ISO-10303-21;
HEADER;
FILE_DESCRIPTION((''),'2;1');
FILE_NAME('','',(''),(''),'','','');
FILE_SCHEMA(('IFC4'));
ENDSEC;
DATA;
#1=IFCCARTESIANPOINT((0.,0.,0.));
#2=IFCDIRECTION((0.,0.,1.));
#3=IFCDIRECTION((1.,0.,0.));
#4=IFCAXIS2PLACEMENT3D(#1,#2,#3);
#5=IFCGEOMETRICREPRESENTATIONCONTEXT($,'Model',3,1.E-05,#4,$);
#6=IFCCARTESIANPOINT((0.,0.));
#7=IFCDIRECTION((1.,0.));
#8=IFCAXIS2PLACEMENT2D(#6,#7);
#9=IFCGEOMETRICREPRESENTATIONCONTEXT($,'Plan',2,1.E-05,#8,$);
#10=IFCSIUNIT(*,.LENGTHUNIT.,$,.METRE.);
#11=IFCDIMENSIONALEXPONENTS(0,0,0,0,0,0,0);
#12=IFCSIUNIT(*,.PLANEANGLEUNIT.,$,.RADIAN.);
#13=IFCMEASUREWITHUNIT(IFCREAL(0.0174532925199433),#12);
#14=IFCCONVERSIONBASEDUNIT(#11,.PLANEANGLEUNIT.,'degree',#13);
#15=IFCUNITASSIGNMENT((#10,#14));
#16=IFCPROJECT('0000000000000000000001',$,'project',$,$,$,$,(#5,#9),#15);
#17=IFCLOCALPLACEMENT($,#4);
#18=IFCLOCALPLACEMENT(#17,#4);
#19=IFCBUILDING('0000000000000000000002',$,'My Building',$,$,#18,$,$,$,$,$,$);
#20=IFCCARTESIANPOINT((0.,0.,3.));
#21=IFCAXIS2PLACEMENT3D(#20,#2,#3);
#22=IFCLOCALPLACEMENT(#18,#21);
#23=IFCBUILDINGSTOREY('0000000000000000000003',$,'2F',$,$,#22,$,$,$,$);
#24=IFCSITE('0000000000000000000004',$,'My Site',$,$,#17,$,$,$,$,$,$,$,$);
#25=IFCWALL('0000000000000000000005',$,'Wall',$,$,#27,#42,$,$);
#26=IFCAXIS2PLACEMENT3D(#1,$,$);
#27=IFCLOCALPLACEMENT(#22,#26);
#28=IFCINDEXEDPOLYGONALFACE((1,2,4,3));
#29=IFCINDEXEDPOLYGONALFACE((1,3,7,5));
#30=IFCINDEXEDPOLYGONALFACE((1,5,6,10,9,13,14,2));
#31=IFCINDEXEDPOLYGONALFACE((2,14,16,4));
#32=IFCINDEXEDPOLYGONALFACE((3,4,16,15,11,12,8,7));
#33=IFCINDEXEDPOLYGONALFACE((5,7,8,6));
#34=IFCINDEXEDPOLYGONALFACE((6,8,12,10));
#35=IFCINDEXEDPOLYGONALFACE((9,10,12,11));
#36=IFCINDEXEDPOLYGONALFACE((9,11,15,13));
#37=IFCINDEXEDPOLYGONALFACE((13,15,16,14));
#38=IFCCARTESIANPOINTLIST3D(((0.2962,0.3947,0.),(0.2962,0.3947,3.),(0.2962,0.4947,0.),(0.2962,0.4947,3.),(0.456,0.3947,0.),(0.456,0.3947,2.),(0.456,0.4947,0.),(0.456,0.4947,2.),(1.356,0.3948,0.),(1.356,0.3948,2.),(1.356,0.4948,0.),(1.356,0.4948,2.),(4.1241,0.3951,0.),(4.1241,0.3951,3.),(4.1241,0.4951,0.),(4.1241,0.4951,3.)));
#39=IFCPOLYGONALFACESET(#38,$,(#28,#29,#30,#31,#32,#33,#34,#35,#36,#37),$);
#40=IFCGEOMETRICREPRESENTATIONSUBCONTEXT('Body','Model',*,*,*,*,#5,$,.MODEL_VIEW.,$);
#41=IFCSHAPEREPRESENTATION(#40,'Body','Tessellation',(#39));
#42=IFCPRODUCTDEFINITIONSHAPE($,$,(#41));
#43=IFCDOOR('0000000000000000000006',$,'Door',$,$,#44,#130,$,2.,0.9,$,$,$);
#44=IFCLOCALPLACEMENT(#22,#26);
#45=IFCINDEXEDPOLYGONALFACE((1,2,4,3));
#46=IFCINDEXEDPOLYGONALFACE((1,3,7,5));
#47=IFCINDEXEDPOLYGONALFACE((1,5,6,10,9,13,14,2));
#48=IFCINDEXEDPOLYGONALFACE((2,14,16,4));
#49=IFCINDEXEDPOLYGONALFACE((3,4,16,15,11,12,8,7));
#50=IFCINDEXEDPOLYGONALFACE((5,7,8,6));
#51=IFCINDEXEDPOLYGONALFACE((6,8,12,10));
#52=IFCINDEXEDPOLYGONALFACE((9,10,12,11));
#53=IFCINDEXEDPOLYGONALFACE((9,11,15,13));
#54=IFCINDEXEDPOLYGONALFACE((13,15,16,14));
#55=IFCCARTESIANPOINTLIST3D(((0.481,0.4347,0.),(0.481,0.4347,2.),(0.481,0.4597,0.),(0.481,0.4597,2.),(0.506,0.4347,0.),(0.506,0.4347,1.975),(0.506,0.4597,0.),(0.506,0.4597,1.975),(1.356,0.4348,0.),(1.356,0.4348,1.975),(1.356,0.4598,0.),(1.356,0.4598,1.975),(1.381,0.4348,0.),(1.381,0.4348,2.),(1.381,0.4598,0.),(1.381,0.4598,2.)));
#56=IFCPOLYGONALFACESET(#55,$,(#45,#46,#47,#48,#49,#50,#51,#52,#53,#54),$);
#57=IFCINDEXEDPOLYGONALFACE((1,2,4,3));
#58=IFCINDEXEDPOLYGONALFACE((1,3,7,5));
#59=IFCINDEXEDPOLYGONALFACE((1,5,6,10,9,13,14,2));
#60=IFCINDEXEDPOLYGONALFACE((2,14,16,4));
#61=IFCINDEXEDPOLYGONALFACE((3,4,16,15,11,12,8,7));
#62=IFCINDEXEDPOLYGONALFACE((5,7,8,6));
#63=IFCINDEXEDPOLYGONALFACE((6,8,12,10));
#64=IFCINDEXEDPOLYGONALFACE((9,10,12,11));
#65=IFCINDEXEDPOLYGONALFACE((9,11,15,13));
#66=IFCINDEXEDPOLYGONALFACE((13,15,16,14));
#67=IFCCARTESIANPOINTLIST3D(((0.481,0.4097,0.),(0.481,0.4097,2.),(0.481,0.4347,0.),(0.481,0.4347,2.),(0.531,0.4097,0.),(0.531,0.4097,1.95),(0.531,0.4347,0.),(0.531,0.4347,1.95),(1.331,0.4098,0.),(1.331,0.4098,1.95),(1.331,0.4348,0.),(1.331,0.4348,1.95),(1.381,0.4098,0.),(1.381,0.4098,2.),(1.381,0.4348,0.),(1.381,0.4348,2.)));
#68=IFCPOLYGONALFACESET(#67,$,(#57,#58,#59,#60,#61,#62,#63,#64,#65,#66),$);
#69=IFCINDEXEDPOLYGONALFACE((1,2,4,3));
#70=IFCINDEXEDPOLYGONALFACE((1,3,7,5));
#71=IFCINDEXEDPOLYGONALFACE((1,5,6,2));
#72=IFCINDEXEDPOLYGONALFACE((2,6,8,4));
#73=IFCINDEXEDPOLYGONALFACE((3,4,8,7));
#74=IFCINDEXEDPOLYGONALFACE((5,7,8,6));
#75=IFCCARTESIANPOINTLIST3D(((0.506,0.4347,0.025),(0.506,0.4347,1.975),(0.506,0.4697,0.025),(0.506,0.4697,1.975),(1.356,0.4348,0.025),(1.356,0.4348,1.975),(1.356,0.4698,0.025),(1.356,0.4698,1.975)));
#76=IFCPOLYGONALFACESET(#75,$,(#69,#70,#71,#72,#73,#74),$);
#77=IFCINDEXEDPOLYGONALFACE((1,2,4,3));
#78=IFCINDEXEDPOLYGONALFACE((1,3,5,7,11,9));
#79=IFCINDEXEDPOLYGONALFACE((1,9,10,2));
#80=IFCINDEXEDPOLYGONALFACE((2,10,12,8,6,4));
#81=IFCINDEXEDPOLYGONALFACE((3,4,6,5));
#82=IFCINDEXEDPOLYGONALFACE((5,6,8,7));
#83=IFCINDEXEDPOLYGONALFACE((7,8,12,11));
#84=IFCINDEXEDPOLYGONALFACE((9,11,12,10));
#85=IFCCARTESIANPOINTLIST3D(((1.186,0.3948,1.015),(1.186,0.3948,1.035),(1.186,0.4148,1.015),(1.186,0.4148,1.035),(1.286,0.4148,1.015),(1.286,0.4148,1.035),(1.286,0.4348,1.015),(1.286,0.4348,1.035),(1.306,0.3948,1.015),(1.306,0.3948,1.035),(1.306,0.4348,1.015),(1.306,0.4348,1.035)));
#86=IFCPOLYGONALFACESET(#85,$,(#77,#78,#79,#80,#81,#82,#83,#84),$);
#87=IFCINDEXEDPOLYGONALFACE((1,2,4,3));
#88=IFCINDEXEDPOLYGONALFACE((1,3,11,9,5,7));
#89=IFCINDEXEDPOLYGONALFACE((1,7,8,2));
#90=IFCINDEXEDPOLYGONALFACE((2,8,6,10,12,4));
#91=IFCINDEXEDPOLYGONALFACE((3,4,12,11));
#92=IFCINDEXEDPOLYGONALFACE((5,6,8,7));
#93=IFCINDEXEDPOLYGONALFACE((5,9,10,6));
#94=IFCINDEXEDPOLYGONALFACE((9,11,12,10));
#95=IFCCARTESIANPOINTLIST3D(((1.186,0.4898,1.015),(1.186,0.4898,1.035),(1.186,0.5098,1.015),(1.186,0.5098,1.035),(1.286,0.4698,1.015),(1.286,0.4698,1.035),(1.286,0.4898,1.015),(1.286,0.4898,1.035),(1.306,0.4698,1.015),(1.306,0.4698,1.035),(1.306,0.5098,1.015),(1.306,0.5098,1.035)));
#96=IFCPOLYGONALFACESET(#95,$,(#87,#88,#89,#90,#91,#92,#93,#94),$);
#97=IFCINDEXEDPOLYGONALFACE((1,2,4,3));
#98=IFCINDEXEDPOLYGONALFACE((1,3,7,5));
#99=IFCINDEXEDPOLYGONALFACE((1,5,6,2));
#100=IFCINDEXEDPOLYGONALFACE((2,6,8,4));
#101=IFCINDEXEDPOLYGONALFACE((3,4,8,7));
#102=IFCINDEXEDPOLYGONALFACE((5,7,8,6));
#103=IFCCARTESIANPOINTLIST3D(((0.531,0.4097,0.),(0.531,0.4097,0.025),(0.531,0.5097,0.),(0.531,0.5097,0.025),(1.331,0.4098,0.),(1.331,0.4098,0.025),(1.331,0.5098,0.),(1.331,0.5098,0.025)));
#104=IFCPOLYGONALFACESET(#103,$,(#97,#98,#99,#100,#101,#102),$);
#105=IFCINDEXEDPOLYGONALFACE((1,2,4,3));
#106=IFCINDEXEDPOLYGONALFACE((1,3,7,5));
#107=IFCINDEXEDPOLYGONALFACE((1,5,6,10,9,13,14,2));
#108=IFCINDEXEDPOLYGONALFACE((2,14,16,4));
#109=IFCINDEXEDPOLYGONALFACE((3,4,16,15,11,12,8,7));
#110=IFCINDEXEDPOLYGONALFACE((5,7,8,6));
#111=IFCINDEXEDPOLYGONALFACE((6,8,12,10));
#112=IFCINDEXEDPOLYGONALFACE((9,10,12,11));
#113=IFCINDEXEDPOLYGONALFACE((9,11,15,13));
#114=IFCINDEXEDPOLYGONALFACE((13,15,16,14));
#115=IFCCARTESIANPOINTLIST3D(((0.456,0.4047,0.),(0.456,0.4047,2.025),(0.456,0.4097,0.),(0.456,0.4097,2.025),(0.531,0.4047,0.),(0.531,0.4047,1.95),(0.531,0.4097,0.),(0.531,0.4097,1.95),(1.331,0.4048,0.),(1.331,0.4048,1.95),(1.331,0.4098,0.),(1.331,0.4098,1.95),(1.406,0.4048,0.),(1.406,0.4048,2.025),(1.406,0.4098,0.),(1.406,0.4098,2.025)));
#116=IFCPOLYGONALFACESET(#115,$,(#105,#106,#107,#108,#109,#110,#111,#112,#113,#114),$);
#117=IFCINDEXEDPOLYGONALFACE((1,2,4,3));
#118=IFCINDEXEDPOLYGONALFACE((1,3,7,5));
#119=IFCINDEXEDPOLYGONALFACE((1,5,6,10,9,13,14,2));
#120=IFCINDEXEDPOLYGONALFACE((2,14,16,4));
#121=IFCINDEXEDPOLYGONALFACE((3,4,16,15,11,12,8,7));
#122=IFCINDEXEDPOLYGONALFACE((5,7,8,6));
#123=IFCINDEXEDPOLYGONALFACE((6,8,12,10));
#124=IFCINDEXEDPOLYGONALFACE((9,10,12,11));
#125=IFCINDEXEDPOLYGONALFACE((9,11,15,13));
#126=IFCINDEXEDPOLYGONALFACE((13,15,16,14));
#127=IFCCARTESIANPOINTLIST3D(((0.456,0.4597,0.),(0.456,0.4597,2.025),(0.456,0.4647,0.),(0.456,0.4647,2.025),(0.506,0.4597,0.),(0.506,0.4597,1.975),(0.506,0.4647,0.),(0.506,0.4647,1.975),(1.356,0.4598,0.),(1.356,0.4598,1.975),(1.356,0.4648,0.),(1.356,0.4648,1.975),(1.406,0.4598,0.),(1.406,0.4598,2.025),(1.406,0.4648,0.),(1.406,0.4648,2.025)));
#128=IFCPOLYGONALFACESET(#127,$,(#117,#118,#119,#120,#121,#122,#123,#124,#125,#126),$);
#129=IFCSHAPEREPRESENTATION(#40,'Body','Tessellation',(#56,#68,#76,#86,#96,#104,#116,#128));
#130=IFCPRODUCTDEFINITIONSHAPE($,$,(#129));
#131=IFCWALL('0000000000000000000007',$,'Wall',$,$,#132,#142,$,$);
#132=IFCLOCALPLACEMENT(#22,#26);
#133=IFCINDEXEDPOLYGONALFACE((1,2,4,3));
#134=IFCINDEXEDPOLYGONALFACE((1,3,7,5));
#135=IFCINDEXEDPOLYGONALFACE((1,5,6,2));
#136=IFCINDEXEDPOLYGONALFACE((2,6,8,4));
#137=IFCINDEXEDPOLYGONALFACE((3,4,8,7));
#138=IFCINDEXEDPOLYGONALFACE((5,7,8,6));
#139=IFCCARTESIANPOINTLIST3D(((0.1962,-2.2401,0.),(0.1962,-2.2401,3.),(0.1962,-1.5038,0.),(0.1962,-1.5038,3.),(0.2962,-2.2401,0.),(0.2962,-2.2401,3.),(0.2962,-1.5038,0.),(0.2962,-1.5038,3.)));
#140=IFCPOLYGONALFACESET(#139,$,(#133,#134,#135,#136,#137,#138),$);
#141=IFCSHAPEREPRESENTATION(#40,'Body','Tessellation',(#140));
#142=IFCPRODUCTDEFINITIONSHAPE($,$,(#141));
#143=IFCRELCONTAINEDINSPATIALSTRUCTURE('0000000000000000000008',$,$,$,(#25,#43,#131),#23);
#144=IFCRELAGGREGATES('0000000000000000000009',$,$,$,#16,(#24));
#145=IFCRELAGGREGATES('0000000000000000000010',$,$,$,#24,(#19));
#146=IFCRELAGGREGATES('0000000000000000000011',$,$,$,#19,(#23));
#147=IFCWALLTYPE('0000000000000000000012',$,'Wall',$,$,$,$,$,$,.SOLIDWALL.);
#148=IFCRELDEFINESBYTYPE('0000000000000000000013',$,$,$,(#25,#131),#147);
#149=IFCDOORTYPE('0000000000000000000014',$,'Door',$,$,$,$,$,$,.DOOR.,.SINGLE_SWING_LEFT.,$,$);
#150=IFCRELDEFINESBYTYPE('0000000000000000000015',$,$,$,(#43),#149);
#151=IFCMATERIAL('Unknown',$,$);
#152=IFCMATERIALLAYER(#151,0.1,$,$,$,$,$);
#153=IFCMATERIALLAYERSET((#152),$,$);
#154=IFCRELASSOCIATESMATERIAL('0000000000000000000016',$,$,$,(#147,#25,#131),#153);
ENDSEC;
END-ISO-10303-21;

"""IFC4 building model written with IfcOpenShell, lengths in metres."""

from ifc_helpers import new_model, entity, si_unit, converted_unit, frame, origin_with_axes, origin_2d_with_axis, place, context, subcontext, project, spatial, line, indexed_curve, outline, extrude, shape, source, transform, mapped, material, layer, layer_set, layer_usage, type_object, type_shapes, element, fill, save


model = new_model("IFC4")

# Units and contexts
model_context = context("Model", 3, precision=1e-05, world=origin_with_axes())
plan_context = context("Plan", 2, precision=1e-05, world=origin_2d_with_axis())
body_context_1 = subcontext(model_context, "Body", "Model", "MODEL_VIEW")
body_context_2 = subcontext(plan_context, "Body", "Plan", "PLAN_VIEW")
ifc_project = project(units=[si_unit("LENGTHUNIT", "METRE"), converted_unit("PLANEANGLEUNIT", "degree", entity("IfcReal", 0.0174532925199433), si_unit("PLANEANGLEUNIT", "RADIAN"), dimensions=[0, 0, 0, 0, 0, 0, 0])], contexts=[model_context, plan_context])

# Site, building, storey
site_placement = place(None, origin_with_axes())
site = spatial("IfcSite", under=ifc_project, at=site_placement, Name="My Site")
building_placement = place(site_placement, origin_with_axes())
building = spatial("IfcBuilding", under=site, at=building_placement, Name="My Building")
storey_placement = place(building_placement, frame((0.0, 0.0, 3.0), z_axis=(0.0, 0.0, 1.0), x_axis=(1.0, 0.0, 0.0)))
storey = spatial("IfcBuildingStorey", under=building, at=storey_placement, Name="2F")

# Shared definitions
ifc_material = material(Name="Unknown")

# Shared definitions
ifc_layer_1 = layer(ifc_material, 0.1)
ifc_layer_set_1 = layer_set([ifc_layer_1])
wall_type = type_object("IfcWallType", Name="Wall", PredefinedType="SOLIDWALL", material=ifc_layer_set_1)

# Shared definitions
shared_shape_1 = source(origin_with_axes(), body_context_1, "Body", "SweptSolid", [
    extrude(outline(indexed_curve([(0.0, 0.0), (0.9, 0.0), (0.9, 2.0), (0.0, 2.0)], segments=[line(1, 2, 3, 4, 1)])), frame((0.0, -0.6, 0.0), z_axis=(0.0, -1.0, 0.0), x_axis=(1.0, 0.0, 0.0)), (0.0, 0.0, -1.0), 1.2),
])
door_type = type_object("IfcDoorType", Name="Door", OperationType="SINGLE_SWING_LEFT", PredefinedType="DOOR")
shared_shape_2 = source(origin_with_axes(), body_context_1, "Body", "SweptSolid", [
    extrude(outline(indexed_curve([(0.0, 0.0), (0.0, 2.0), (0.9, 2.0), (0.9, 0.0), (0.875, 0.0), (0.875, 1.975), (0.025, 1.975), (0.025, 0.0)], segments=[line(1, 2, 3, 4, 5, 6, 7, 8, 1)])), frame((0.0, 0.025, 0.0), z_axis=(0.0, -1.0, 0.0), x_axis=(1.0, 0.0, 0.0)), (0.0, 0.0, -1.0), 0.025),
    extrude(outline(indexed_curve([(0.0, 0.0), (0.0, 2.0), (0.9, 2.0), (0.9, 0.0), (0.85, 0.0), (0.85, 1.95), (0.05, 1.95), (0.05, 0.0)], segments=[line(1, 2, 3, 4, 5, 6, 7, 8, 1)])), frame((0.0, 0.0, 0.0), z_axis=(0.0, -1.0, 0.0), x_axis=(1.0, 0.0, 0.0)), (0.0, 0.0, -1.0), 0.025),
    extrude(outline(indexed_curve([(0.0, 0.0), (0.85, 0.0), (0.85, 0.035), (0.0, 0.035)], segments=[line(1, 2, 3, 4, 1)])), frame((0.025, 0.025, 0.025), z_axis=(0.0, 0.0, 1.0), x_axis=(1.0, 0.0, 0.0)), (0.0, 0.0, 1.0), 1.95),
    extrude(outline(indexed_curve([(0.0, 0.0), (0.0, -0.04), (-0.12, -0.04), (-0.12, -0.02), (-0.02, -0.02), (-0.02, 0.0)], segments=[line(1, 2, 3, 4, 5, 6, 1)])), frame((0.825, 0.025, 1.015), z_axis=(0.0, 0.0, 1.0), x_axis=(1.0, 0.0, 0.0)), (0.0, 0.0, 1.0), 0.02),
    extrude(outline(indexed_curve([(0.0, 0.0), (0.0, 0.04), (-0.12, 0.04), (-0.12, 0.02), (-0.02, 0.02), (-0.02, 0.0)], segments=[line(1, 2, 3, 4, 5, 6, 1)])), frame((0.825, 0.06, 1.015), z_axis=(0.0, 0.0, 1.0), x_axis=(1.0, 0.0, 0.0)), (0.0, 0.0, 1.0), 0.02),
    extrude(outline(indexed_curve([(0.0, 0.0), (0.8, 0.0), (0.8, 0.1), (0.0, 0.1)], segments=[line(1, 2, 3, 4, 1)])), frame((0.05, 0.0, 0.0), z_axis=(0.0, 0.0, 1.0), x_axis=(1.0, 0.0, 0.0)), (0.0, 0.0, 1.0), 0.025),
    extrude(outline(indexed_curve([(0.0, 0.0), (0.0, 2.025), (0.95, 2.025), (0.95, 0.0), (0.875, 0.0), (0.875, 1.95), (0.075, 1.95), (0.075, 0.0)], segments=[line(1, 2, 3, 4, 5, 6, 7, 8, 1)])), frame((-0.025, -0.005, 0.0), z_axis=(0.0, -1.0, 0.0), x_axis=(1.0, 0.0, 0.0)), (0.0, 0.0, -1.0), 0.005),
    extrude(outline(indexed_curve([(0.0, 0.0), (0.0, 2.025), (0.95, 2.025), (0.95, 0.0), (0.9, 0.0), (0.9, 1.975), (0.05, 1.975), (0.05, 0.0)], segments=[line(1, 2, 3, 4, 5, 6, 7, 8, 1)])), frame((-0.025, 0.05, 0.0), z_axis=(0.0, -1.0, 0.0), x_axis=(1.0, 0.0, 0.0)), (0.0, 0.0, -1.0), 0.005),
])
shared_shape_3 = source(origin_with_axes(), body_context_2, "Body", "Curve2D", [
    entity("IfcIndexedPolyCurve", entity("IfcCartesianPointList2D", [[0.0, 0.0], [0.0, 0.05], [0.025, 0.05], [0.025, 0.025], [0.05, 0.025], [0.05, 0.0]]), [entity("IfcLineIndex", [1, 2, 3, 4, 5, 6, 1])]),
    entity("IfcIndexedPolyCurve", entity("IfcCartesianPointList2D", [[0.9, 0.0], [0.9, 0.05], [0.875, 0.05], [0.875, 0.025], [0.85, 0.025], [0.85, 0.0]]), [entity("IfcLineIndex", [1, 2, 3, 4, 5, 6, 1])]),
    entity("IfcTrimmedCurve", entity("IfcEllipse", entity("IfcAxis2Placement2D", entity("IfcCartesianPoint", [0.06, 0.05]), entity("IfcDirection", [1.0, 0.0])), 0.815, 0.85), [entity("IfcCartesianPoint", [0.875, 0.05])], [entity("IfcCartesianPoint", [0.06, 0.9])], True, "CARTESIAN"),
    entity("IfcIndexedPolyCurve", entity("IfcCartesianPointList2D", [[0.025, 0.05], [0.06, 0.05], [0.06, 0.9], [0.025, 0.9]]), [entity("IfcLineIndex", [1, 2, 3, 4, 1])]),
])
type_shapes(door_type, [shared_shape_2, shared_shape_3])

# Wall, opening, door
ifc_layer_usage_1 = layer_usage(ifc_layer_set_1, "AXIS2", "POSITIVE", 0.0)
wall_1_placement = place(storey_placement, frame((4.1241, 0.4951, 0.0), z_axis=(0.0, 0.0, 1.0), x_axis=(-1.0, -0.000094, 0.0)))
wall_1 = element("IfcWall", 1, at=wall_1_placement, inside=storey, type_object=wall_type, material=ifc_layer_usage_1, Name="Wall", context=body_context_1, shape_type="SweptSolid", body=[
    extrude(outline(indexed_curve([(0.0, 0.0), (0.0, 0.1), (3.8279, 0.1), (3.8279, 0.0)], segments=[line(1, 2, 3, 4, 1)])), origin_with_axes(), (0.0, 0.0, 1.0), 3.0),
])
opening_1_placement = place(wall_1_placement, frame((2.7681, 0.0, 0.0), z_axis=(0.0, 0.0, 1.0), x_axis=(1.0, 0.0, 0.0)))
opening_1 = element("IfcOpeningElement", 2, at=opening_1_placement, cuts=wall_1, PredefinedType="OPENING", context=body_context_1, shape_type="MappedRepresentation", body=[
    mapped(shared_shape_1, transform((0.0, 0.0, 0.0), x_axis=(1.0, 0.0, 0.0), y_axis=(0.0, 1.0, 0.0), z_axis=(0.0, 0.0, 1.0), scale=1.0)),
])
door_1_placement = place(opening_1_placement, frame((0.875, 0.085, 0.0), z_axis=(0.0, 0.0, 1.0), x_axis=(-1.0, 0.0, 0.0)))
door_1 = element("IfcDoor", 3, at=door_1_placement, inside=storey, type_object=door_type, Name="Door", OverallHeight=2.0, OverallWidth=0.9, shapes=[
    shape(body_context_1, "Body", "MappedRepresentation", [mapped(shared_shape_2, transform((0.0, 0.0, 0.0), x_axis=(1.0, 0.0, 0.0), y_axis=(0.0, 1.0, 0.0), z_axis=(0.0, 0.0, 1.0), scale=1.0))]),
    shape(body_context_2, "Body", "MappedRepresentation", [mapped(shared_shape_3, transform((0.0, 0.0, 0.0), x_axis=(1.0, 0.0, 0.0), y_axis=(0.0, 1.0, 0.0), z_axis=(0.0, 0.0, 1.0), scale=1.0))]),
])
fill(opening_1, door_1)

# Wall
ifc_layer_usage_2 = layer_usage(ifc_layer_set_1, "AXIS2", "POSITIVE", 0.0)
wall_2_placement = place(storey_placement, frame((0.1962, -1.5038, 0.0), z_axis=(0.0, 0.0, 1.0), x_axis=(0.0, -1.0, 0.0)))
element("IfcWall", 4, at=wall_2_placement, inside=storey, type_object=wall_type, material=ifc_layer_usage_2, Name="Wall", context=body_context_1, shape_type="SweptSolid", body=[
    extrude(outline(indexed_curve([(0.0, 0.0), (0.0, 0.1), (0.7362, 0.1), (0.7362, 0.0)], segments=[line(1, 2, 3, 4, 1)])), origin_with_axes(), (0.0, 0.0, 1.0), 3.0),
])

save(model, "model.ifc")
